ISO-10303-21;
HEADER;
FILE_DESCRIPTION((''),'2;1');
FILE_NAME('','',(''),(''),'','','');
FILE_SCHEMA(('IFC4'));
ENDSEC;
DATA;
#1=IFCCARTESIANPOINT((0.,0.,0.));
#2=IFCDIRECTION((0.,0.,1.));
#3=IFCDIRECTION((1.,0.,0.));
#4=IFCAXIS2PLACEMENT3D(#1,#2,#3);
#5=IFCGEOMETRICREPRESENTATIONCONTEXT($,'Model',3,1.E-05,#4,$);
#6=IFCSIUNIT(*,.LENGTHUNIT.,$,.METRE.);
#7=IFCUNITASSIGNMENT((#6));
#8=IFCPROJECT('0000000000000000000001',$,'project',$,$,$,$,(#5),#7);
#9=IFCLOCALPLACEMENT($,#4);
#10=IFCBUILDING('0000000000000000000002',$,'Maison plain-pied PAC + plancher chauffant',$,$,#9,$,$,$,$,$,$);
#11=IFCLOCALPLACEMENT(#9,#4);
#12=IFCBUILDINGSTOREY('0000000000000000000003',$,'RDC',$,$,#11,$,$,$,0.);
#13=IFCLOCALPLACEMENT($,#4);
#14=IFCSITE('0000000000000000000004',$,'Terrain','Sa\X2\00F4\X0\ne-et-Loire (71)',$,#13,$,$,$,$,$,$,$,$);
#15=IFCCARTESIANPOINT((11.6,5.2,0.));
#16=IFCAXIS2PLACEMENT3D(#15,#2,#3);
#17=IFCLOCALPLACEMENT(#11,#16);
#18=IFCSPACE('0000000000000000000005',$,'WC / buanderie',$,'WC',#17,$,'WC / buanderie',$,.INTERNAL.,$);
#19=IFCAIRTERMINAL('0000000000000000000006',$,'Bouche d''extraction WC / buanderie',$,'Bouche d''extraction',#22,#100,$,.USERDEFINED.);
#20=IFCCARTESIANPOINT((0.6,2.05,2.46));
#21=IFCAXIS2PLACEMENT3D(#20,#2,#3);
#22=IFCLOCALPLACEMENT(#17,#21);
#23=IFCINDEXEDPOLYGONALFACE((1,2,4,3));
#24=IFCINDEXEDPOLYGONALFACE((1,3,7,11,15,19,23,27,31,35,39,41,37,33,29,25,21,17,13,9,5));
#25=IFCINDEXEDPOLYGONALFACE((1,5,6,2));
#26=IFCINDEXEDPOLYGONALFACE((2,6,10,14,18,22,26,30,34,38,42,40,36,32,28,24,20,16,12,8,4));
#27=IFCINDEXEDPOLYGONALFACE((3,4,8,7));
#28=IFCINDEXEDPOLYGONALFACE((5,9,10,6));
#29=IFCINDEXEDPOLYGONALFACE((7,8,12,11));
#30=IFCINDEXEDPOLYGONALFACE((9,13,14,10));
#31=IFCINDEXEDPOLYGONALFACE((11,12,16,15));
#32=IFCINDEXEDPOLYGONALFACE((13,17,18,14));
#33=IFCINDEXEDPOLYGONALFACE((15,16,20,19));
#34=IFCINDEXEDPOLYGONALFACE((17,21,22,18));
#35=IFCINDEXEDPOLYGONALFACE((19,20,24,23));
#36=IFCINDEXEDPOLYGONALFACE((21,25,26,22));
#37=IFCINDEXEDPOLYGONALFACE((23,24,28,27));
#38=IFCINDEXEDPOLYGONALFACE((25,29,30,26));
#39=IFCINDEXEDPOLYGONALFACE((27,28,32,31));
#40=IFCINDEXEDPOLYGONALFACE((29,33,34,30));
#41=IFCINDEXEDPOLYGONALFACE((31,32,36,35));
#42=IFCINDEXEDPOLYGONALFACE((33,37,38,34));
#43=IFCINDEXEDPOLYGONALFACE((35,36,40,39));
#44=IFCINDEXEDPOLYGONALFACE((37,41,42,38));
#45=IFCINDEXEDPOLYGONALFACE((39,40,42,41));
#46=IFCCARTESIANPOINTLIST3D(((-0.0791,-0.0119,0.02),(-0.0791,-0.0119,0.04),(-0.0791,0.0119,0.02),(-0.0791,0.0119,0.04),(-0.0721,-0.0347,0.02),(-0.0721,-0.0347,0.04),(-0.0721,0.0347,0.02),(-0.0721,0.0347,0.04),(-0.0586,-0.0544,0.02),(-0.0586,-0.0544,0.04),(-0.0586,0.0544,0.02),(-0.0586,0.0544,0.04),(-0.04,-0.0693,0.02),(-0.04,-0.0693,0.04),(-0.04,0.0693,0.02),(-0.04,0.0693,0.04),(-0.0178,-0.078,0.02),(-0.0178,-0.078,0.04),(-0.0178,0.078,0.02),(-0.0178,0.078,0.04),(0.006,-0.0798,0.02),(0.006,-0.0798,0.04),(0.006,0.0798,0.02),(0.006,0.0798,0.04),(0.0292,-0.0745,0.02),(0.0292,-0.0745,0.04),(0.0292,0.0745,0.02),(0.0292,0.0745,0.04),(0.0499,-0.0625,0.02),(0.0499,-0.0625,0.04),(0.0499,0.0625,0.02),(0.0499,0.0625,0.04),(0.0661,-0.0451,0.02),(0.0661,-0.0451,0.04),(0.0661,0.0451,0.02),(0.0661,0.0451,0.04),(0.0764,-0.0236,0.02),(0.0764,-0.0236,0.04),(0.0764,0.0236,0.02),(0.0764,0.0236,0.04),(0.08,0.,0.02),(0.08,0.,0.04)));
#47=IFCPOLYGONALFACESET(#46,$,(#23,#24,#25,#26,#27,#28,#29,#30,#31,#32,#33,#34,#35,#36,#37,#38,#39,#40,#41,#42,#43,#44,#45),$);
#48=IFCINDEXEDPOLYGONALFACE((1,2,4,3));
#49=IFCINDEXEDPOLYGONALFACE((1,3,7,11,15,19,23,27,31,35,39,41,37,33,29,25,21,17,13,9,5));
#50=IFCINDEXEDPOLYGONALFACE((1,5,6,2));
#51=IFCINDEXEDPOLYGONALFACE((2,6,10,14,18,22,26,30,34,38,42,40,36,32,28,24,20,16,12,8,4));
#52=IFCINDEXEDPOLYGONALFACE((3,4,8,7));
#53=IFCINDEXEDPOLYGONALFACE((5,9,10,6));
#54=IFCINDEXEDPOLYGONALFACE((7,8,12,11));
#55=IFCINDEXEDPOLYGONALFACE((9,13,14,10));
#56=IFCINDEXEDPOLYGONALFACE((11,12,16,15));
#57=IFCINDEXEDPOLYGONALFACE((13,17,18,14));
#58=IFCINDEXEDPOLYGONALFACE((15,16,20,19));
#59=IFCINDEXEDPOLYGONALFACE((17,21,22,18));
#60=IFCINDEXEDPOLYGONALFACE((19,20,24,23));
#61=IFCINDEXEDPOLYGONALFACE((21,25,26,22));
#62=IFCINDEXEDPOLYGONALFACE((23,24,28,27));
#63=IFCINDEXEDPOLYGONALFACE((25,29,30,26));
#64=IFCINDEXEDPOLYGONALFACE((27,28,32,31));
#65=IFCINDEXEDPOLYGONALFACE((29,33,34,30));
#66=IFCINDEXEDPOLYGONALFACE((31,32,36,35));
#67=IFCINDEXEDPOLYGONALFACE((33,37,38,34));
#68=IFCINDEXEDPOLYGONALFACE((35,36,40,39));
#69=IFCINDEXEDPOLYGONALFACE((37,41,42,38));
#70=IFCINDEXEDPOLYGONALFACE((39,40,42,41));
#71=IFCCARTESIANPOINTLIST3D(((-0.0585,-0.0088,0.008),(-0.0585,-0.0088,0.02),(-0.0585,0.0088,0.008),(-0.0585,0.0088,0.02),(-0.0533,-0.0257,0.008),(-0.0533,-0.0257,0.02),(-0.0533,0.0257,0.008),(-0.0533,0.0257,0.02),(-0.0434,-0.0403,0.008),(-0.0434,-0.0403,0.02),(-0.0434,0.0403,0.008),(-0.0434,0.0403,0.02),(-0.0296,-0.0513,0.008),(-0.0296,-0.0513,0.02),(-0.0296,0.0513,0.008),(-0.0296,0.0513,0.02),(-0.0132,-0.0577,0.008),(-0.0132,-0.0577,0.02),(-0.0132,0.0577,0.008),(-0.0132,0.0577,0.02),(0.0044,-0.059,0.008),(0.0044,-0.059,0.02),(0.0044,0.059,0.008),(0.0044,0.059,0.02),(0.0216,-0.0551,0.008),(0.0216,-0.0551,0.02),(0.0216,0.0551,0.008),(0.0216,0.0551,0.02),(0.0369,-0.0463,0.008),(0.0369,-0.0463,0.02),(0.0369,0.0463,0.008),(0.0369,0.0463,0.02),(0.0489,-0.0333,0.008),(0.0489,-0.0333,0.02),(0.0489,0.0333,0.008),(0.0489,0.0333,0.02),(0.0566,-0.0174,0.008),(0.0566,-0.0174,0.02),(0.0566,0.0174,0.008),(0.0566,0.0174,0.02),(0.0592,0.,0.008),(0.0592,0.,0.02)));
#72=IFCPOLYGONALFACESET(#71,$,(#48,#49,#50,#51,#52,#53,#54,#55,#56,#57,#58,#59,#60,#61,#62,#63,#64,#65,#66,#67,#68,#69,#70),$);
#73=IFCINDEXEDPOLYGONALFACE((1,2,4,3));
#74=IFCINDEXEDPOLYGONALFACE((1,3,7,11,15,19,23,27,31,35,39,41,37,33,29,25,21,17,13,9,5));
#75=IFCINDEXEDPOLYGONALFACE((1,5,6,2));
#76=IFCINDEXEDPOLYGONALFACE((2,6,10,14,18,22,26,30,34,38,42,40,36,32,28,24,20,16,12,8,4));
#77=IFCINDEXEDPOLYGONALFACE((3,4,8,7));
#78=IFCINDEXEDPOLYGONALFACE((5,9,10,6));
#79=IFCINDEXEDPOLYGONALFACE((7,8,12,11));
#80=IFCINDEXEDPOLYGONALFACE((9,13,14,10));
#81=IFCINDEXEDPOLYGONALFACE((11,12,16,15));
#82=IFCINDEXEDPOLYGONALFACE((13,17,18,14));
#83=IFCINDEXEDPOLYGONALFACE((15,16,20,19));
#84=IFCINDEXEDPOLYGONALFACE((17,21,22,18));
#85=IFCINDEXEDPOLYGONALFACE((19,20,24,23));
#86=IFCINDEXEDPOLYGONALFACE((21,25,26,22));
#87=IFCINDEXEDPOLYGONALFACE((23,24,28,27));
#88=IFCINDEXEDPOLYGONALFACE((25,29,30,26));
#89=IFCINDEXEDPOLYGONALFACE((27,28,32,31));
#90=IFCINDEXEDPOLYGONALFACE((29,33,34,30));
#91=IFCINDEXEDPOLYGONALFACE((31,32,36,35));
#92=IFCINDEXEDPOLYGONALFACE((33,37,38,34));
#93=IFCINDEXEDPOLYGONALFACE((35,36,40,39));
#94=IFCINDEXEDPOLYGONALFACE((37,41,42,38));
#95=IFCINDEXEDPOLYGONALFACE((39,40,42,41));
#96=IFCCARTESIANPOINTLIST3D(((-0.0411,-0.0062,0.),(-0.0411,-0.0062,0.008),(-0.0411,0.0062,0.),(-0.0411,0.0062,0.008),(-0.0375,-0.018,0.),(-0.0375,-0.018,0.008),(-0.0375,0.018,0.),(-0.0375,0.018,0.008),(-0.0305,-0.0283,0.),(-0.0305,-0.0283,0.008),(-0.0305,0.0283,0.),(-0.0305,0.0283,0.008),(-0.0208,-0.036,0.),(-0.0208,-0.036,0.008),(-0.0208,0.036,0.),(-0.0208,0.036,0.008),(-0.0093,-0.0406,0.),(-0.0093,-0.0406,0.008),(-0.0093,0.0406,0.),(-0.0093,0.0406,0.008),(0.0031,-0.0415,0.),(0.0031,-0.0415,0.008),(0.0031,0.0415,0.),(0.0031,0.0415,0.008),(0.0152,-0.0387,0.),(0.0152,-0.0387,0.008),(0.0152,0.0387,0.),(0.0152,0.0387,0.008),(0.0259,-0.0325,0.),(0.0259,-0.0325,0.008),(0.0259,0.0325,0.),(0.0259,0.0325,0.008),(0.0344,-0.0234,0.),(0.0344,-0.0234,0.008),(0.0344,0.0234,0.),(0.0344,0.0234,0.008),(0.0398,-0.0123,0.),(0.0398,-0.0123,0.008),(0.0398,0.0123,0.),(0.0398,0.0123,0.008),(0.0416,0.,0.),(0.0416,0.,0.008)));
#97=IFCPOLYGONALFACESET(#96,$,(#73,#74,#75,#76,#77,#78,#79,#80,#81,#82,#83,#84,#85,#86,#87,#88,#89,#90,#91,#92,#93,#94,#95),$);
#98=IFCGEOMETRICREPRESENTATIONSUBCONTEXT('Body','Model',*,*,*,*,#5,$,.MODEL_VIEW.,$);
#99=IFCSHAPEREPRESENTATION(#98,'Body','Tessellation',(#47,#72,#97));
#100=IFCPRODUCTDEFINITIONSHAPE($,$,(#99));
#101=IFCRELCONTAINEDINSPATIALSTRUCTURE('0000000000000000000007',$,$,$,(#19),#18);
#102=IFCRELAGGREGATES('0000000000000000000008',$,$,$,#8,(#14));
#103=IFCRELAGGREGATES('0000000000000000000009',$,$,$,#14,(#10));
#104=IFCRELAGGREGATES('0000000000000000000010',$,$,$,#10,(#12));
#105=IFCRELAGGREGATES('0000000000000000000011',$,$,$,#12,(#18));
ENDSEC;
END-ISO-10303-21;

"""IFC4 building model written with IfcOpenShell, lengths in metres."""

from ifc_helpers import new_model, si_unit, frame, origin_with_axes, place, context, subcontext, project, spatial, circle, extrude, element, save


model = new_model("IFC4")

# Units and contexts
model_context = context("Model", 3, precision=1e-05, world=origin_with_axes())
body_context = subcontext(model_context, "Body", "Model", "MODEL_VIEW")
ifc_project = project(units=[si_unit("LENGTHUNIT", "METRE")], contexts=[model_context])

# Site, building, storey
site_placement = place(None, origin_with_axes())
site = spatial("IfcSite", under=ifc_project, at=site_placement, Name="Terrain", Description="Saône-et-Loire (71)")
building_placement = place(None, origin_with_axes())
building = spatial("IfcBuilding", under=site, at=building_placement, Name="Maison plain-pied PAC + plancher chauffant")
storey_placement = place(building_placement, origin_with_axes())
storey = spatial("IfcBuildingStorey", under=building, at=storey_placement, Name="RDC", Elevation=0.0)

# Shared definitions
space_placement = place(storey_placement, frame((11.6, 5.2, 0.0), z_axis=(0.0, 0.0, 1.0), x_axis=(1.0, 0.0, 0.0)))
space = spatial("IfcSpace", under=storey, at=space_placement, Name="WC / buanderie", ObjectType="WC", LongName="WC / buanderie", PredefinedType="INTERNAL")

# Air terminal
air_terminal_placement = place(space_placement, frame((0.6, 2.05, 2.46), z_axis=(0.0, 0.0, 1.0), x_axis=(1.0, 0.0, 0.0)))
element("IfcAirTerminal", 1, at=air_terminal_placement, inside=space, Name="Bouche d'extraction WC / buanderie", ObjectType="Bouche d'extraction", PredefinedType="USERDEFINED", context=body_context, shape_type="SweptSolid", body=[
    extrude(circle(Radius=0.08), frame((0.0, 0.0, 0.02), z_axis=(0.0, 0.0, 1.0), x_axis=(1.0, 0.0, 0.0)), (0.0, 0.0, 1.0), 0.02),
    extrude(circle(Radius=0.0592), frame((0.0, 0.0, 0.008), z_axis=(0.0, 0.0, 1.0), x_axis=(1.0, 0.0, 0.0)), (0.0, 0.0, 1.0), 0.012),
    extrude(circle(Radius=0.0416), origin_with_axes(), (0.0, 0.0, 1.0), 0.008),
])

save(model, "model.ifc")
